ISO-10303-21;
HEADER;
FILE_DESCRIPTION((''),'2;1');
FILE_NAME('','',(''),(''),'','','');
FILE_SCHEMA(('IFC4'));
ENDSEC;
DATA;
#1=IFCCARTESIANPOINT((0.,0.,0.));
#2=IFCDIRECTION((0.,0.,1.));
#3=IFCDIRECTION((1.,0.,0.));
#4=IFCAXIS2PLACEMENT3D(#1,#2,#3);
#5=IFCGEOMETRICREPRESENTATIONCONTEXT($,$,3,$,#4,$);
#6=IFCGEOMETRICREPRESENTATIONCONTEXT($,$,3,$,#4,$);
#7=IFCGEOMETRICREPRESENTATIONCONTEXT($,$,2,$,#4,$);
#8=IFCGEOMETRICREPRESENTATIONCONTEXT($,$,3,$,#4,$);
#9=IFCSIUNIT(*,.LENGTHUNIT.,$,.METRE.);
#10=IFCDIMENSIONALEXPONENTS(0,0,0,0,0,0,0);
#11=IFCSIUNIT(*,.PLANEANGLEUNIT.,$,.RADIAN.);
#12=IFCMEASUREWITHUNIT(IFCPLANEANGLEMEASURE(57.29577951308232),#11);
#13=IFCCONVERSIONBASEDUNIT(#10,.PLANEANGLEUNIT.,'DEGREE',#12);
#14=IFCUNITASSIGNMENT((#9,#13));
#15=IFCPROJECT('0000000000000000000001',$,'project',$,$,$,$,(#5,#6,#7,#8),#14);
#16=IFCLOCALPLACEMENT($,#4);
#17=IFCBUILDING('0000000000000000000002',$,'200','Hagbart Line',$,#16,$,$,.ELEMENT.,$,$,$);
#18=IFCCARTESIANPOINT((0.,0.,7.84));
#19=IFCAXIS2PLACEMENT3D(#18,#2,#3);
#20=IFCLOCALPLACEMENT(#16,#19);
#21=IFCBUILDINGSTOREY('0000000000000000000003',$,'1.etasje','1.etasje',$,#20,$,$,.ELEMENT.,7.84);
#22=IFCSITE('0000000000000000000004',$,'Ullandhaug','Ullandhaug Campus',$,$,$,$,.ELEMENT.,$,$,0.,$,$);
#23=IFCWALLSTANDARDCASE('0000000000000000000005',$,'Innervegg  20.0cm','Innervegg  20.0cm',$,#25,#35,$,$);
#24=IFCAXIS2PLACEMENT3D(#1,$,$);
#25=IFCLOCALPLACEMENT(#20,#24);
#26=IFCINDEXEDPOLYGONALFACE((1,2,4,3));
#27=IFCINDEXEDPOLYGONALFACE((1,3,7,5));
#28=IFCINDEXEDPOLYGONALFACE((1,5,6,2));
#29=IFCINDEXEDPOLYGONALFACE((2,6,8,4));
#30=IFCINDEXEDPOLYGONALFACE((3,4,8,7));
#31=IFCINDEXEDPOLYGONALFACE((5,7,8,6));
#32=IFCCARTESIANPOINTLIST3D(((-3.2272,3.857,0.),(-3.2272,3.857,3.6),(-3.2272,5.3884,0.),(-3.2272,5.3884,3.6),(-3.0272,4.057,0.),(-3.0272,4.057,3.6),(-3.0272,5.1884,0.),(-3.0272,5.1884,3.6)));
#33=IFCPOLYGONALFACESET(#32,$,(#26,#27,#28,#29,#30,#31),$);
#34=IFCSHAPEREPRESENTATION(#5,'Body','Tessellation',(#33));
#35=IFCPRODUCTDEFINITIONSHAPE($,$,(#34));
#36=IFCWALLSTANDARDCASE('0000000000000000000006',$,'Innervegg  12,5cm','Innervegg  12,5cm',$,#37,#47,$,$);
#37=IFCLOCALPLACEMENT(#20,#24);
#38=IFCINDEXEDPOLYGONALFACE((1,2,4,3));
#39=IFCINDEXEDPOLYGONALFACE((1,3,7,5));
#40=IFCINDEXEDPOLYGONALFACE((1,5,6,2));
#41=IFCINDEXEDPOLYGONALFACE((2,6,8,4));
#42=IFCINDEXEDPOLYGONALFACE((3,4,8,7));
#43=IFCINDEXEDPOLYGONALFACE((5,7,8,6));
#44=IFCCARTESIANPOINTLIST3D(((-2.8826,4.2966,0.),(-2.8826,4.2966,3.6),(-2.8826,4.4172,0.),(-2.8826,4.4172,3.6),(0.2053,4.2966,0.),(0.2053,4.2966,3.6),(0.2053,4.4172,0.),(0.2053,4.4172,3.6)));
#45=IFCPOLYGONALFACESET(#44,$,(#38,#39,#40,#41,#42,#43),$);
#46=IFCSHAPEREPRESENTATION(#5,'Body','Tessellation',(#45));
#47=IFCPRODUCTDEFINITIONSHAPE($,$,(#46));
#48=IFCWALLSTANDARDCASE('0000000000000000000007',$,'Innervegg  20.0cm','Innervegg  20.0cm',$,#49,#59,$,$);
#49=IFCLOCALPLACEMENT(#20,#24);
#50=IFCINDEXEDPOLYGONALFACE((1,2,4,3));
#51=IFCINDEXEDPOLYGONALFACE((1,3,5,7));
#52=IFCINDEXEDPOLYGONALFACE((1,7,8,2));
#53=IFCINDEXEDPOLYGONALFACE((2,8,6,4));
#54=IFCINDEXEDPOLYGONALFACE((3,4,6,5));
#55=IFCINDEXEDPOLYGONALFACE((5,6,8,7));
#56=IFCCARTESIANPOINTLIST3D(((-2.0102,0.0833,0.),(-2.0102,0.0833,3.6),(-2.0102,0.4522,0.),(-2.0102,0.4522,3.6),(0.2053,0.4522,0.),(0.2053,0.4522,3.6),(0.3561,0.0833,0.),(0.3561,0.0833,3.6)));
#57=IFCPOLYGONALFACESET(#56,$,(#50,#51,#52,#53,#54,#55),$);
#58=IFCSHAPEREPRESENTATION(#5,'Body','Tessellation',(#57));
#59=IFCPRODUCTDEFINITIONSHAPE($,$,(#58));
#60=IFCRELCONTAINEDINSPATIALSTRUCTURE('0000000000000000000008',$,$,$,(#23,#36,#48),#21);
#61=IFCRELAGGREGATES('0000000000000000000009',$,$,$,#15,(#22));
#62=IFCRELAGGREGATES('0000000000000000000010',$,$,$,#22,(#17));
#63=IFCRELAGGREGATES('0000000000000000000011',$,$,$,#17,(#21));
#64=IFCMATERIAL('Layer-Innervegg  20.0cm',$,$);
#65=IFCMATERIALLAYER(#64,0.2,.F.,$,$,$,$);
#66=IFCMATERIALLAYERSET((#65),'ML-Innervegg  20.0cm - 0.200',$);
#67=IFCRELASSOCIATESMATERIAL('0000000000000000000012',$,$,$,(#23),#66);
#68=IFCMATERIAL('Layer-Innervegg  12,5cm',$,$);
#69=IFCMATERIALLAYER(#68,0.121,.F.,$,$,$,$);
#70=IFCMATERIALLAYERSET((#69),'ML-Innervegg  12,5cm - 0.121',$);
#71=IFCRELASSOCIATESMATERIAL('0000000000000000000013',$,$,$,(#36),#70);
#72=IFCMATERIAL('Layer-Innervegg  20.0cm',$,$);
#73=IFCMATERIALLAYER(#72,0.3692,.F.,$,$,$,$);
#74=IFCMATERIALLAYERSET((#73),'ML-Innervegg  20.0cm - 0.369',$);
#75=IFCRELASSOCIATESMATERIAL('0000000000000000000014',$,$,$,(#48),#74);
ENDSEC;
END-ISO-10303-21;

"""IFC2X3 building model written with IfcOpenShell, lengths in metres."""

from ifc_helpers import new_model, entity, si_unit, converted_unit, frame, origin_with_axes, place, context, project, spatial, polyline, outline, extrude, material, layer, layer_set, layer_usage, element, save


model = new_model("IFC2X3")

# Units and contexts
context_of_model_1 = context(None, 3, world=origin_with_axes())
context_of_model_2 = context(None, 3, world=origin_with_axes())
context_of_model_3 = context(None, 2, world=origin_with_axes())
context_of_model_4 = context(None, 3, world=origin_with_axes())
ifc_project = project(units=[si_unit("LENGTHUNIT", "METRE"), converted_unit("PLANEANGLEUNIT", "DEGREE", entity("IfcPlaneAngleMeasure", 57.29577951308232), si_unit("PLANEANGLEUNIT", "RADIAN"), dimensions=[0, 0, 0, 0, 0, 0, 0])], contexts=[context_of_model_1, context_of_model_2, context_of_model_3, context_of_model_4])

# Site, building, storey
site = spatial("IfcSite", under=ifc_project, Name="Ullandhaug", Description="Ullandhaug Campus", CompositionType="ELEMENT", RefElevation=0.0)
building_placement = place(None, origin_with_axes())
building = spatial("IfcBuilding", under=site, at=building_placement, Name="200", Description="Hagbart Line", CompositionType="ELEMENT")
storey_placement = place(building_placement, frame((0.0, 0.0, 7.84), z_axis=(0.0, 0.0, 1.0), x_axis=(1.0, 0.0, 0.0)))
storey = spatial("IfcBuildingStorey", under=building, at=storey_placement, Name="1.etasje", Description="1.etasje", CompositionType="ELEMENT", Elevation=7.84)

# Shared definitions
ifc_material_1 = material(Name="Layer-Innervegg  20.0cm")
ifc_layer_1 = layer(ifc_material_1, 0.3692, ventilated=False)
ifc_layer_set_1 = layer_set([ifc_layer_1], Name="ML-Innervegg  20.0cm - 0.369")
ifc_layer_usage_1 = layer_usage(ifc_layer_set_1, "AXIS2", "POSITIVE", 0.0)
ifc_material_2 = material(Name="Layer-Innervegg  20.0cm")
ifc_layer_2 = layer(ifc_material_2, 0.2, ventilated=False)
ifc_layer_set_2 = layer_set([ifc_layer_2], Name="ML-Innervegg  20.0cm - 0.200")
ifc_layer_usage_2 = layer_usage(ifc_layer_set_2, "AXIS2", "POSITIVE", 0.0)

# Walls
wall_1_placement = place(storey_placement, frame((-3.0272, 4.057, 0.0), z_axis=(0.0, 0.0, 1.0), x_axis=(0.0, 1.0, 0.0)))
element("IfcWallStandardCase", 1, at=wall_1_placement, inside=storey, material=ifc_layer_usage_2, Name="Innervegg  20.0cm", Description="Innervegg  20.0cm", context=context_of_model_1, shape_type="SweptSolid", body=[
    extrude(outline(polyline([(0.0, 0.0), (1.1314, 0.0), (1.3314, 0.2), (-0.2, 0.2), (0.0, 0.0)])), frame((0.0, 0.0, 0.0), z_axis=(0.0, 0.0, 1.0), x_axis=(1.0, 0.0, 0.0)), (0.0, 0.0, 1.0), 3.6),
])
ifc_material_3 = material(Name="Layer-Innervegg  12,5cm")
ifc_layer_3 = layer(ifc_material_3, 0.121, ventilated=False)
ifc_layer_set_3 = layer_set([ifc_layer_3], Name="ML-Innervegg  12,5cm - 0.121")
ifc_layer_usage_3 = layer_usage(ifc_layer_set_3, "AXIS2", "POSITIVE", 0.0)
wall_2_placement = place(storey_placement, frame((-2.8826, 4.2966, 0.0), z_axis=(0.0, 0.0, 1.0), x_axis=(1.0, 0.0, 0.0)))
element("IfcWallStandardCase", 2, at=wall_2_placement, inside=storey, material=ifc_layer_usage_3, Name="Innervegg  12,5cm", Description="Innervegg  12,5cm", context=context_of_model_1, shape_type="SweptSolid", body=[
    extrude(outline(polyline([(0.0, 0.0), (3.0879, 0.0), (3.0879, 0.1206), (0.0, 0.1206), (0.0, 0.0)])), origin_with_axes(), (0.0, 0.0, 1.0), 3.6),
])
wall_3_placement = place(storey_placement, frame((-2.0102, 0.0833, 0.0), z_axis=(0.0, 0.0, 1.0), x_axis=(1.0, 0.0, 0.0)))
element("IfcWallStandardCase", 3, at=wall_3_placement, inside=storey, material=ifc_layer_usage_1, Name="Innervegg  20.0cm", Description="Innervegg  20.0cm", context=context_of_model_1, shape_type="SweptSolid", body=[
    extrude(outline(polyline([(0.0, 0.0), (2.3663, 0.0), (2.2156, 0.3689), (0.0, 0.3689), (0.0, 0.0)])), frame((0.0, 0.0, 0.0), z_axis=(0.0, 0.0, 1.0), x_axis=(1.0, 0.0, 0.0)), (0.0, 0.0, 1.0), 3.6),
])

save(model, "model.ifc")
